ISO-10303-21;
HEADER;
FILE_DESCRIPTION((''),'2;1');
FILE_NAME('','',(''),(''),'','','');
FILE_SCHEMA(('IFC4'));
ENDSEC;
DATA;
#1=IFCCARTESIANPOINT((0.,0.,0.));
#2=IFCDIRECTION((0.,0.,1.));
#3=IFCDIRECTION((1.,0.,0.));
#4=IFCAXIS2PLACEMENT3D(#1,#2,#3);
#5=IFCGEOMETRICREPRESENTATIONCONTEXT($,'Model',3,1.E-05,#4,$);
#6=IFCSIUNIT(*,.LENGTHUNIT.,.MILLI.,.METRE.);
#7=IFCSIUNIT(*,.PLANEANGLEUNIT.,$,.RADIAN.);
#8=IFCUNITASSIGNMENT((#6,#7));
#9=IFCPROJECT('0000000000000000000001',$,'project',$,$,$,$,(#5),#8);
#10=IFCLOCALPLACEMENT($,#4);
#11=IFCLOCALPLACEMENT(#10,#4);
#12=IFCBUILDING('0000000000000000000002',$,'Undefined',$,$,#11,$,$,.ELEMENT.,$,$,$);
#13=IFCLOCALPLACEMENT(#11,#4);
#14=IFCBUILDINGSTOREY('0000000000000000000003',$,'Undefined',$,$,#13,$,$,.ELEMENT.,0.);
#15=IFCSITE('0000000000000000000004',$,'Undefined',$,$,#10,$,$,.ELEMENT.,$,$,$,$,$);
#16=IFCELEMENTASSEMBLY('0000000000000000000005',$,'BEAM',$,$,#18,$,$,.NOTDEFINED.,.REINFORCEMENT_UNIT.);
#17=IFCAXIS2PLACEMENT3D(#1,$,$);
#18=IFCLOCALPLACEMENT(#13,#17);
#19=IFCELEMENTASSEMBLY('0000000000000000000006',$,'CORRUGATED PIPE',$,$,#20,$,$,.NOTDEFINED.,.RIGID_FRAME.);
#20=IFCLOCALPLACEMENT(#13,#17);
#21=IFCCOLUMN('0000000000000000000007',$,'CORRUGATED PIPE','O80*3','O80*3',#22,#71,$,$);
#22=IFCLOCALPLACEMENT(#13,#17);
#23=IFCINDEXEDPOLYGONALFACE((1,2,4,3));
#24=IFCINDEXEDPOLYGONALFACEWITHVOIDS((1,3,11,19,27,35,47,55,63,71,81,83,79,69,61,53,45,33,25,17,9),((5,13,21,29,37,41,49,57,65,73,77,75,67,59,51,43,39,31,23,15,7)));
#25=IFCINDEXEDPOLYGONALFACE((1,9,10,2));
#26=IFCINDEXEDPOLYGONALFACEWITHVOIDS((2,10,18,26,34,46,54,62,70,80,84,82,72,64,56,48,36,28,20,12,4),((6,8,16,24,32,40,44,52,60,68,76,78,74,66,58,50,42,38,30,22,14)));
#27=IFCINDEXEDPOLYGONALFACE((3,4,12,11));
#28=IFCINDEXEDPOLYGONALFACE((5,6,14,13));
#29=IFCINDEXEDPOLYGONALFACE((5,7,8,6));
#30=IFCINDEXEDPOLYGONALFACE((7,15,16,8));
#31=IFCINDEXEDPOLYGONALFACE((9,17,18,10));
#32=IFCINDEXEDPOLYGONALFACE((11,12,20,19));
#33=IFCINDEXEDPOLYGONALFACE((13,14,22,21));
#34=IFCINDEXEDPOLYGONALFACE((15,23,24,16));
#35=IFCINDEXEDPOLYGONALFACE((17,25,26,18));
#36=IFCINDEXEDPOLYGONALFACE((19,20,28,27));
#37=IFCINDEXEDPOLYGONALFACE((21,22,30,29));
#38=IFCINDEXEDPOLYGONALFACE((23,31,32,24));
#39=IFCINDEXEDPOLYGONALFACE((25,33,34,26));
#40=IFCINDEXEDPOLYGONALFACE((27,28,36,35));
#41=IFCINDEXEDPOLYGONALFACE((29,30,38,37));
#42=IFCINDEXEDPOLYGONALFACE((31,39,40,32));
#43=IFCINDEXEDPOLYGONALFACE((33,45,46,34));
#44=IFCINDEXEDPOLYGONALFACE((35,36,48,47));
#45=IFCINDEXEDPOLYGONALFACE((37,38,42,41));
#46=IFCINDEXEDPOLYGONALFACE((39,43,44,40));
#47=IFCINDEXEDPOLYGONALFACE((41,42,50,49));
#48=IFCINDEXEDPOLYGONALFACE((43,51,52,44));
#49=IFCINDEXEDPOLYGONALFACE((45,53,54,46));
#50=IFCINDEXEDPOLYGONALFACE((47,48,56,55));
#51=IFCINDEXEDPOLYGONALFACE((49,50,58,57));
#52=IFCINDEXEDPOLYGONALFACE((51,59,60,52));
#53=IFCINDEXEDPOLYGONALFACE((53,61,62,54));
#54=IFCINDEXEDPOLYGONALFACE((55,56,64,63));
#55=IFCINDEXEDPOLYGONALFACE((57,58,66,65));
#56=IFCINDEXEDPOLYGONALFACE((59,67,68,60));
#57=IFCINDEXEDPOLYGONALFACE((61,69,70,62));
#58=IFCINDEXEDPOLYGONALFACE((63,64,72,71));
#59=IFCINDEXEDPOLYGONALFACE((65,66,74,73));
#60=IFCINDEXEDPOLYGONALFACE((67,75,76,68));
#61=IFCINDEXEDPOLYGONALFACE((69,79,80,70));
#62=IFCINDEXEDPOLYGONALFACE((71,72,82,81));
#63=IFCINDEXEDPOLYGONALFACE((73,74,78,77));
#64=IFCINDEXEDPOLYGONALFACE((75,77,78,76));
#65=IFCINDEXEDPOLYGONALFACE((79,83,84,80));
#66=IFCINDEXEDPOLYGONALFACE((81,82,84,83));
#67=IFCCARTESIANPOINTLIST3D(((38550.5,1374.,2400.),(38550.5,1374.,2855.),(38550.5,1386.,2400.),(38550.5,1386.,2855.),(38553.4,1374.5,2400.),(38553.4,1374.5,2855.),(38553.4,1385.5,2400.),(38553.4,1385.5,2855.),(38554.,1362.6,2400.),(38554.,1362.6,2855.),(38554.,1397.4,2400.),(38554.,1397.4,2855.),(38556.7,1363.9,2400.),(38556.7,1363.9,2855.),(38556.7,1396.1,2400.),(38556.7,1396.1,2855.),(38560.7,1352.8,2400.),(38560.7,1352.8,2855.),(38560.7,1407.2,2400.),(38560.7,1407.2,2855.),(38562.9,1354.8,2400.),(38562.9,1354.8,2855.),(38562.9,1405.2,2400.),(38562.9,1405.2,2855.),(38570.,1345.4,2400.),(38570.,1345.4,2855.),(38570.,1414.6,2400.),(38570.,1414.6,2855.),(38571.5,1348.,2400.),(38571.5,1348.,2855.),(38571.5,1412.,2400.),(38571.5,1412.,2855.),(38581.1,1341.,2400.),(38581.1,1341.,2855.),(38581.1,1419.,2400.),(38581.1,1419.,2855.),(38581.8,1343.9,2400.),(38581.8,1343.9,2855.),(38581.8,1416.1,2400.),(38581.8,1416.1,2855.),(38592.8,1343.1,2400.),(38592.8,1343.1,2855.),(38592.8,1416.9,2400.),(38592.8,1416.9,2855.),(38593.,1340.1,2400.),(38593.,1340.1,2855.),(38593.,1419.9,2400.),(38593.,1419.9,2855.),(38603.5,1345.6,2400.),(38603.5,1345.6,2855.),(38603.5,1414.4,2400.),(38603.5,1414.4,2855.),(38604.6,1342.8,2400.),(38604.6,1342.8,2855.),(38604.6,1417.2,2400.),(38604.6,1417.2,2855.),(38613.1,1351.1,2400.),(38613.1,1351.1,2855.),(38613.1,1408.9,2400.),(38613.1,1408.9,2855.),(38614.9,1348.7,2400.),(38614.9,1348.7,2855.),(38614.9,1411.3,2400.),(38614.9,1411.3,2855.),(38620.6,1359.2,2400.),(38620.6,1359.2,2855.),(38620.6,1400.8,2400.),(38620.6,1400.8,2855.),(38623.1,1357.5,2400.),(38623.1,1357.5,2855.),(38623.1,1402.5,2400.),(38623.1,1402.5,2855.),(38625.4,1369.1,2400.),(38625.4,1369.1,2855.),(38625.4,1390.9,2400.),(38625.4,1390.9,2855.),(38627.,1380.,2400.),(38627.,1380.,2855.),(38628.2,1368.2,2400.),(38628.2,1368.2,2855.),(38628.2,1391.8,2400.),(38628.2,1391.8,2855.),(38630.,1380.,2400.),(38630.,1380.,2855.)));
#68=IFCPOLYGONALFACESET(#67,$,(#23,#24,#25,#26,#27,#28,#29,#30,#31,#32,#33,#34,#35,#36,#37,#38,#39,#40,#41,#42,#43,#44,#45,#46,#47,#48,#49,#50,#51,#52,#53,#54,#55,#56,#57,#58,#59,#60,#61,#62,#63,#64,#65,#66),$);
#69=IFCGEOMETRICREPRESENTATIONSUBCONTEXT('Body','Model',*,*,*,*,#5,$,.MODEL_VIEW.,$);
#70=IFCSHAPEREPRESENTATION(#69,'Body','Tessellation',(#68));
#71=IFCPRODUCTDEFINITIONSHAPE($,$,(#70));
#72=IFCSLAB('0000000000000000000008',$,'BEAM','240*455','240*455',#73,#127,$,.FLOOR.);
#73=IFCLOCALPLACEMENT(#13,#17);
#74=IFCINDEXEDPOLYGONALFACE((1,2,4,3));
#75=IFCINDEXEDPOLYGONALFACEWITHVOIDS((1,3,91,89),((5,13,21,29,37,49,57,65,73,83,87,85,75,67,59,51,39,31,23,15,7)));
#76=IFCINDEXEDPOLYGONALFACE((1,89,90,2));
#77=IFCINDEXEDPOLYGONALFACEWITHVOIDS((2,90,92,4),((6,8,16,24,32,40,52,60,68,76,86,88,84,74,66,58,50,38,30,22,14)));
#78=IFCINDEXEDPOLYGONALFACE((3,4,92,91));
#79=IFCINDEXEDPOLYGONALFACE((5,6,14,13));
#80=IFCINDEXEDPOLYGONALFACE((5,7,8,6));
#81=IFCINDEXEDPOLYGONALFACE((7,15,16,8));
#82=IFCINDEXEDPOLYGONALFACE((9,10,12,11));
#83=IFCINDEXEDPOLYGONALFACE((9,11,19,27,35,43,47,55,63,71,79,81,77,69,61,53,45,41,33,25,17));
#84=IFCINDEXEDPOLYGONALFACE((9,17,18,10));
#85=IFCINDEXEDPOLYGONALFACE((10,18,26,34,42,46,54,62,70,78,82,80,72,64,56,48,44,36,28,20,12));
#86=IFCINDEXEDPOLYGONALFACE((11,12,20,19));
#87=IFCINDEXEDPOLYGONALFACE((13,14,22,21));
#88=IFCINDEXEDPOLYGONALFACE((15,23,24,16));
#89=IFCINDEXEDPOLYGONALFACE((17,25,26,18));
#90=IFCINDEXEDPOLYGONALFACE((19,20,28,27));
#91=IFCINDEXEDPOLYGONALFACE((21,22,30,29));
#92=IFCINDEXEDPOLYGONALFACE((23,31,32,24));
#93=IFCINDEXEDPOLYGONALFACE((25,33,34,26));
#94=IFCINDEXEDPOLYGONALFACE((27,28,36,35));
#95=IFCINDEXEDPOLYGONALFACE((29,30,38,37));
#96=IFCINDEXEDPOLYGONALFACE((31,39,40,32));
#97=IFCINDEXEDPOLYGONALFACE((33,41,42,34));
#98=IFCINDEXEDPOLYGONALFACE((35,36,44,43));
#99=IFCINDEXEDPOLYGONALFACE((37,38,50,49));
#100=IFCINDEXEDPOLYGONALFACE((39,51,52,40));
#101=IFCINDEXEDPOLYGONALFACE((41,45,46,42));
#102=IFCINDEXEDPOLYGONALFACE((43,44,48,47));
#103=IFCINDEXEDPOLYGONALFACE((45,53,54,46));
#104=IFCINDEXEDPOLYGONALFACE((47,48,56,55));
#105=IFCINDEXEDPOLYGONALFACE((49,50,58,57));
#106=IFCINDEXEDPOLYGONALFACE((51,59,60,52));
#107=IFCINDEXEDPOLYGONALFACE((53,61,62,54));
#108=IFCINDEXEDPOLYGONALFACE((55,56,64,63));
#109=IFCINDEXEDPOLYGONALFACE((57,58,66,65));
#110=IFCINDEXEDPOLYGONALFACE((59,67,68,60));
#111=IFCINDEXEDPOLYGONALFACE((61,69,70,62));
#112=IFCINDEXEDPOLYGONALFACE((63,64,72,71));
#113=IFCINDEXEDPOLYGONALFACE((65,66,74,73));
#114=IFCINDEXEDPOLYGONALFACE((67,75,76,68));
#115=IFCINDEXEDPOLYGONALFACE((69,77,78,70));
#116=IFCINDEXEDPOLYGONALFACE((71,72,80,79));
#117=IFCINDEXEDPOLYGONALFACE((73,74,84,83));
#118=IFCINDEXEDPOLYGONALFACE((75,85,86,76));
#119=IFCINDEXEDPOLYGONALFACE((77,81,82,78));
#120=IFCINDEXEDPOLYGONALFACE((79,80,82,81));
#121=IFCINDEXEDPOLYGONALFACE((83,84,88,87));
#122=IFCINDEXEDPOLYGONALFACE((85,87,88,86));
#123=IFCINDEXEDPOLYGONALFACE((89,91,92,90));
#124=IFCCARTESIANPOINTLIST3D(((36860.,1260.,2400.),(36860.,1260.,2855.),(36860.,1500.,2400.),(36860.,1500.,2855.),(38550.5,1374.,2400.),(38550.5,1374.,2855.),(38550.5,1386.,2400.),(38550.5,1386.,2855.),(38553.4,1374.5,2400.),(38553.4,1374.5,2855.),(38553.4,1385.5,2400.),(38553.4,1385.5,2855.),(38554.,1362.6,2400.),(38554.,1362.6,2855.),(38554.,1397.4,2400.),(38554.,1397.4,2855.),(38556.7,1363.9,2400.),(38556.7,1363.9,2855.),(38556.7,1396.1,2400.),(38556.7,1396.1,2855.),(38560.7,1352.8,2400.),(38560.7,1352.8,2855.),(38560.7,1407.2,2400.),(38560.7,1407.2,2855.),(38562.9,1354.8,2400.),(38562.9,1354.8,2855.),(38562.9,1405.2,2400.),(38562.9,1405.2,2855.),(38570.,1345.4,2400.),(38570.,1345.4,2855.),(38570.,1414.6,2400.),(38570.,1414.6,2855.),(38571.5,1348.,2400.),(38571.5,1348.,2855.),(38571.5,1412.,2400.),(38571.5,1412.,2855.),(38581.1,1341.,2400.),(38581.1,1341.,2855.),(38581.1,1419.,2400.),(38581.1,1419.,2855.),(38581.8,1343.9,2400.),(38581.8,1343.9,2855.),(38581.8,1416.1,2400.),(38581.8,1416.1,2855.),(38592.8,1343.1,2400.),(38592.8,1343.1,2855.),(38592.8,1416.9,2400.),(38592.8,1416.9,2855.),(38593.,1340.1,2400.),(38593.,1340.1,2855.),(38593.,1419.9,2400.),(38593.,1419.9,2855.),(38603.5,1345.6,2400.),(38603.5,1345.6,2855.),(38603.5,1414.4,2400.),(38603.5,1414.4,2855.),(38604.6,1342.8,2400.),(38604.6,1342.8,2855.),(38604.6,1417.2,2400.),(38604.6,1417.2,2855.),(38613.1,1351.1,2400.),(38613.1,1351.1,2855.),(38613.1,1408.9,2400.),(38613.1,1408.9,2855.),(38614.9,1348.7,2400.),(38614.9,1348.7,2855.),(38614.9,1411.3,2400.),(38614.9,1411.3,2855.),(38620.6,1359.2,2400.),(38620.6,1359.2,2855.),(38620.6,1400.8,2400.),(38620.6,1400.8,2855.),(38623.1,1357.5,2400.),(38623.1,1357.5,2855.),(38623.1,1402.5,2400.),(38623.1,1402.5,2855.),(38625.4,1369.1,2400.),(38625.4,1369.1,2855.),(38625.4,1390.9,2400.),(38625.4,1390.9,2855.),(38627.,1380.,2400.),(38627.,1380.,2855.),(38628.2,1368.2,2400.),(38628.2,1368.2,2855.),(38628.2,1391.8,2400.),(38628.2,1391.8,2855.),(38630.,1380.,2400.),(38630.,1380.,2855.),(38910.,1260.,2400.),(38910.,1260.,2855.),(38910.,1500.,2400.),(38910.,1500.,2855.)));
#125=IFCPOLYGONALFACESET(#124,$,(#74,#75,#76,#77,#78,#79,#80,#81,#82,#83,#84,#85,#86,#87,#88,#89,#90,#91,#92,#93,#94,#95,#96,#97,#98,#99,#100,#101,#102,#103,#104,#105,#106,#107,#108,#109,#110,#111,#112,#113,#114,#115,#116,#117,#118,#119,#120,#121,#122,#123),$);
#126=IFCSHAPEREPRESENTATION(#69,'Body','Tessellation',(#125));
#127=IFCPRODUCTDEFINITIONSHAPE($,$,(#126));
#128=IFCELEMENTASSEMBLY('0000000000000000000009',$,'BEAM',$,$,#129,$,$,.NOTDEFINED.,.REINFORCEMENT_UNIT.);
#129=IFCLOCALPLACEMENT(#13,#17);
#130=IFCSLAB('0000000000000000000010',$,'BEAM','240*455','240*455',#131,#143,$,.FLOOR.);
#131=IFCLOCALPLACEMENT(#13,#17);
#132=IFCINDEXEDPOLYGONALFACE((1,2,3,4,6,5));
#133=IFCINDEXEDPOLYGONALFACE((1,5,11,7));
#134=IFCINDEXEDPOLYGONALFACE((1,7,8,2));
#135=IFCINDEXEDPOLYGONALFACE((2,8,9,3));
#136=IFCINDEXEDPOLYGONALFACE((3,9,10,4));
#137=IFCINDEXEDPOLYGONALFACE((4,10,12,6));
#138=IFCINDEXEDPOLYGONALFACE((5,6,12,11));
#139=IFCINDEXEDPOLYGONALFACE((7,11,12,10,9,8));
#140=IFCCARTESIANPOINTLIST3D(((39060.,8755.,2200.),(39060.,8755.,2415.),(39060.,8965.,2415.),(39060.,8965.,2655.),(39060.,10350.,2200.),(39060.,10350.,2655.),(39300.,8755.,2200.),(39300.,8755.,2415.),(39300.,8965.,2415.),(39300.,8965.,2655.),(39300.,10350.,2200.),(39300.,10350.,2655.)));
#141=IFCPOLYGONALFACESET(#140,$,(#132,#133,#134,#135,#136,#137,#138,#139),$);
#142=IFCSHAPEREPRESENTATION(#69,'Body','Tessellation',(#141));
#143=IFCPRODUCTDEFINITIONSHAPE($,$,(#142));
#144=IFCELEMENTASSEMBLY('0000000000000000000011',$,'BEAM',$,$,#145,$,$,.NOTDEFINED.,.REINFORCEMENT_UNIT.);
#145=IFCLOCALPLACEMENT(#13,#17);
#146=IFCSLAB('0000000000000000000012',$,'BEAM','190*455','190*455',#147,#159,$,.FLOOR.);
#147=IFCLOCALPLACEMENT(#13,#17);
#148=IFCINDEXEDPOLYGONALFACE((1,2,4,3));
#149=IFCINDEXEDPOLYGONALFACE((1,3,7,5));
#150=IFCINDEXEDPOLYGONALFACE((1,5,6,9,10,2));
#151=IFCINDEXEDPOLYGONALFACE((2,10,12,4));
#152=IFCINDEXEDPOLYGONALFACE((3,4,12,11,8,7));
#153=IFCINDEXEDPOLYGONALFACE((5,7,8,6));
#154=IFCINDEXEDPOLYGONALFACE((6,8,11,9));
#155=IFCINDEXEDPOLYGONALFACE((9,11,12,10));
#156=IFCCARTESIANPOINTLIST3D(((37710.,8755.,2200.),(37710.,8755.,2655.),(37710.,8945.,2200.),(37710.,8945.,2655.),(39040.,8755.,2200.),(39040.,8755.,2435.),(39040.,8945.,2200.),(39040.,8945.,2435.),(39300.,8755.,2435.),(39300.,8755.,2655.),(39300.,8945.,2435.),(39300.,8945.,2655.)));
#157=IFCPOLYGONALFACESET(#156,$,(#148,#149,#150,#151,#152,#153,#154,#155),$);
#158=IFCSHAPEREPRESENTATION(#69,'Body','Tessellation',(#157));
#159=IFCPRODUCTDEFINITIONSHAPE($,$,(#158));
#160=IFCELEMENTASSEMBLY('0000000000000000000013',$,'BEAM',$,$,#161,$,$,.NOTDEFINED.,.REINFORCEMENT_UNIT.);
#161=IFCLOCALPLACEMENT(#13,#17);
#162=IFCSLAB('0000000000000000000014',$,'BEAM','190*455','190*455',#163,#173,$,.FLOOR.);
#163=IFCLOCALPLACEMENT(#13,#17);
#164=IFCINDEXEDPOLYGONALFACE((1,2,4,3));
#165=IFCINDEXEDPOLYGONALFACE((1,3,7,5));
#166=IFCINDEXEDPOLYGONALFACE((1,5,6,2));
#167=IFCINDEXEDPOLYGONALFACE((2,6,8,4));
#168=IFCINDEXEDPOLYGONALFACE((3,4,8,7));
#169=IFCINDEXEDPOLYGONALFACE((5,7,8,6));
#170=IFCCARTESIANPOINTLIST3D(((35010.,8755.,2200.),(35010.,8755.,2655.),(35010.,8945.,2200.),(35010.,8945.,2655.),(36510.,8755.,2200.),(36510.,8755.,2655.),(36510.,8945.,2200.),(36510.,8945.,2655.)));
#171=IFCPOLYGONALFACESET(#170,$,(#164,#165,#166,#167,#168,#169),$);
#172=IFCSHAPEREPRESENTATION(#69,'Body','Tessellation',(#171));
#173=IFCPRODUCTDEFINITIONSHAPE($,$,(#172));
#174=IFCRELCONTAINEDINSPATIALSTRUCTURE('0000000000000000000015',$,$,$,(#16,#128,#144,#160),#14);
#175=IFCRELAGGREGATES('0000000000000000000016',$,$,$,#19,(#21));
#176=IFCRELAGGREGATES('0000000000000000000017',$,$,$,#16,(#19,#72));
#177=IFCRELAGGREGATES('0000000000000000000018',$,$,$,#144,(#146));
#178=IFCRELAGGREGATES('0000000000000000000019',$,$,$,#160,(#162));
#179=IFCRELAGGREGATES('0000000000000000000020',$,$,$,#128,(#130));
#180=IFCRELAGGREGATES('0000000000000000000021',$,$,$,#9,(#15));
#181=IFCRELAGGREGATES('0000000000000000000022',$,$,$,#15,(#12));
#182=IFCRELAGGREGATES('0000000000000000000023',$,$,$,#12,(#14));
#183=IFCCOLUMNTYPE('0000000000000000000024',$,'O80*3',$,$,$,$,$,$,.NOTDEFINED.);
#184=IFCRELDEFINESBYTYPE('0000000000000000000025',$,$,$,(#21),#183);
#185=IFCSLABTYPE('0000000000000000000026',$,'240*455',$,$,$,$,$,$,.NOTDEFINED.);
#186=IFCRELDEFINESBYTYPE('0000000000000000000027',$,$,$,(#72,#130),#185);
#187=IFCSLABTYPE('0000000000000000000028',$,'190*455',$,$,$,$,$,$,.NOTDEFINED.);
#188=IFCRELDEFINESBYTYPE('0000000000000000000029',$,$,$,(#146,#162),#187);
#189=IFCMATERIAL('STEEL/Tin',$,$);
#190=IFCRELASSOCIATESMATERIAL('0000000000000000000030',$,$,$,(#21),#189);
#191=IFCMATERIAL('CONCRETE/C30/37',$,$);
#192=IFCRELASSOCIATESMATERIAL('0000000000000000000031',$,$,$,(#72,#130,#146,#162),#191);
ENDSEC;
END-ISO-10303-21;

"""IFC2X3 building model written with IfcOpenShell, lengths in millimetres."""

from ifc_helpers import new_model, si_unit, frame, origin_with_axes, origin_2d_with_axis, place, context, subcontext, project, spatial, polyline, hollow_circle, outline, extrude, boolean, material, type_object, element, aggregate, save


model = new_model("IFC2X3")

# Units and contexts
model_context = context("Model", 3, precision=1e-05, world=origin_with_axes())
body_context = subcontext(model_context, "Body", "Model", "MODEL_VIEW")
ifc_project = project(units=[si_unit("LENGTHUNIT", "METRE", prefix="MILLI"), si_unit("PLANEANGLEUNIT", "RADIAN")], contexts=[model_context])

# Site, building, storey
site_placement = place(None, origin_with_axes())
site = spatial("IfcSite", under=ifc_project, at=site_placement, Name="Undefined", CompositionType="ELEMENT")
building_placement = place(site_placement, origin_with_axes())
building = spatial("IfcBuilding", under=site, at=building_placement, Name="Undefined", CompositionType="ELEMENT")
storey_placement = place(building_placement, origin_with_axes())
storey = spatial("IfcBuildingStorey", under=building, at=storey_placement, Name="Undefined", CompositionType="ELEMENT", Elevation=0.0)

# Element assemblies, column, slab
assembly_1_placement = place(storey_placement, origin_with_axes())
assembly_1 = element("IfcElementAssembly", 1, at=assembly_1_placement, inside=storey, Name="BEAM", AssemblyPlace="NOTDEFINED", PredefinedType="REINFORCEMENT_UNIT")
assembly_2_placement = place(assembly_1_placement, origin_with_axes())
assembly_2 = element("IfcElementAssembly", 2, at=assembly_2_placement, Name="CORRUGATED PIPE", AssemblyPlace="NOTDEFINED", PredefinedType="RIGID_FRAME")
ifc_material_1 = material(Name="STEEL/Tin")
column_type = type_object("IfcColumnType", Name="O80*3", PredefinedType="NOTDEFINED")
column_placement = place(assembly_2_placement, frame((38590.0, 1380.0, 2400.0), z_axis=(0.0, 0.0, 1.0), x_axis=(0.0, -1.0, 0.0)))
column = element("IfcColumn", 3, at=column_placement, type_object=column_type, material=ifc_material_1, Name="CORRUGATED PIPE", Description="O80*3", ObjectType="O80*3", context=body_context, shape_type="SweptSolid", body=[
    extrude(hollow_circle(Radius=40.0, WallThickness=3.0, at=origin_2d_with_axis()), frame((0.0, 0.0, 455.0), z_axis=(0.0, 0.0, -1.0), x_axis=(0.0, 1.0, 0.0)), (0.0, 0.0, 1.0), 455.0),
])
aggregate(assembly_2, [column])
ifc_material_2 = material(Name="CONCRETE/C30/37")
slab_type_1 = type_object("IfcSlabType", Name="240*455", PredefinedType="NOTDEFINED")
slab_1_placement = place(assembly_1_placement, frame((36860.0, 1380.0, 2400.0), z_axis=(0.0, 1.0, 0.0), x_axis=(0.0, 0.0, 1.0)))
slab_1 = element("IfcSlab", 4, at=slab_1_placement, type_object=slab_type_1, material=ifc_material_2, Name="BEAM", Description="240*455", ObjectType="240*455", PredefinedType="FLOOR", context=body_context, shape_type="CSG", body=[
    boolean("DIFFERENCE", extrude(outline(polyline([(0.0, 0.0), (455.0, 0.0), (455.0, 2050.0), (0.0, 2050.0), (0.0, 0.0)])), frame((0.0, 0.0, -120.0), z_axis=(0.0, 0.0, 1.0), x_axis=(1.0, 0.0, 0.0)), (0.0, 0.0, 1.0), 240.0), extrude(hollow_circle(Radius=40.0, WallThickness=3.0, at=origin_2d_with_axis()), frame((455.0, 1730.0, 0.0), z_axis=(-1.0, 0.0, 0.0), x_axis=(0.0, 1.0, 0.0)), (0.0, 0.0, 1.0), 455.0)),
])

# Element assemblies, slabs
assembly_3_placement = place(storey_placement, origin_with_axes())
assembly_3 = element("IfcElementAssembly", 5, at=assembly_3_placement, inside=storey, Name="BEAM", AssemblyPlace="NOTDEFINED", PredefinedType="REINFORCEMENT_UNIT")
slab_2_placement = place(assembly_3_placement, frame((39180.0, 8755.0, 2200.0), z_axis=(-1.0, 0.0, 0.0), x_axis=(0.0, 0.0, 1.0)))
slab_2 = element("IfcSlab", 6, at=slab_2_placement, type_object=slab_type_1, material=ifc_material_2, Name="BEAM", Description="240*455", ObjectType="240*455", PredefinedType="FLOOR", context=body_context, shape_type="CSG", body=[
    boolean("DIFFERENCE", extrude(outline(polyline([(0.0, 0.0), (455.0, 0.0), (455.0, 1595.0), (0.0, 1595.0), (0.0, 0.0)])), frame((0.0, 0.0, -120.0), z_axis=(0.0, 0.0, 1.0), x_axis=(1.0, 0.0, 0.0)), (0.0, 0.0, 1.0), 240.0), extrude(outline(polyline([(0.0, 0.0), (210.0, 0.0), (210.0, 240.0), (0.0, 240.0), (0.0, 0.0)])), frame((455.0, 0.0, -125.0), z_axis=(0.0, 0.0, 1.0), x_axis=(0.0, 1.0, 0.0)), (0.0, 0.0, 1.0), 250.0)),
])
assembly_4_placement = place(storey_placement, origin_with_axes())
assembly_4 = element("IfcElementAssembly", 7, at=assembly_4_placement, inside=storey, Name="BEAM", AssemblyPlace="NOTDEFINED", PredefinedType="REINFORCEMENT_UNIT")
slab_type_2 = type_object("IfcSlabType", Name="190*455", PredefinedType="NOTDEFINED")
slab_3_placement = place(assembly_4_placement, frame((37710.0, 8850.0, 2200.0), z_axis=(0.0, 1.0, 0.0), x_axis=(0.0, 0.0, 1.0)))
slab_3 = element("IfcSlab", 8, at=slab_3_placement, type_object=slab_type_2, material=ifc_material_2, Name="BEAM", Description="190*455", ObjectType="190*455", PredefinedType="FLOOR", context=body_context, shape_type="CSG", body=[
    boolean("DIFFERENCE", extrude(outline(polyline([(0.0, 0.0), (455.0, 0.0), (455.0, 1590.0), (0.0, 1590.0), (0.0, 0.0)])), frame((0.0, 0.0, -95.0), z_axis=(0.0, 0.0, 1.0), x_axis=(1.0, 0.0, 0.0)), (0.0, 0.0, 1.0), 190.0), extrude(outline(polyline([(0.0, 0.0), (260.0, 0.0), (260.0, 235.0), (0.0, 235.0), (0.0, 0.0)])), frame((0.0, 1590.0, -100.0), z_axis=(0.000018, 0.0, 1.0), x_axis=(0.0, -1.0, 0.0)), (0.0, 0.0, 1.0), 200.0)),
])
assembly_5_placement = place(storey_placement, origin_with_axes())
assembly_5 = element("IfcElementAssembly", 9, at=assembly_5_placement, inside=storey, Name="BEAM", AssemblyPlace="NOTDEFINED", PredefinedType="REINFORCEMENT_UNIT")
slab_4_placement = place(assembly_5_placement, frame((35010.0, 8850.0, 2200.0), z_axis=(0.0, 1.0, 0.0), x_axis=(0.0, 0.0, 1.0)))
slab_4 = element("IfcSlab", 10, at=slab_4_placement, type_object=slab_type_2, material=ifc_material_2, Name="BEAM", Description="190*455", ObjectType="190*455", PredefinedType="FLOOR", context=body_context, shape_type="SweptSolid", body=[
    extrude(outline(polyline([(0.0, 0.0), (455.0, 0.0), (455.0, 1500.0), (0.0, 1500.0), (0.0, 0.0)])), frame((0.0, 0.0, -95.0), z_axis=(0.0, 0.0, 1.0), x_axis=(1.0, 0.0, 0.0)), (0.0, 0.0, 1.0), 190.0),
])

aggregate(assembly_1, [assembly_2, slab_1])
aggregate(assembly_4, [slab_3])
aggregate(assembly_5, [slab_4])
aggregate(assembly_3, [slab_2])

save(model, "model.ifc")
